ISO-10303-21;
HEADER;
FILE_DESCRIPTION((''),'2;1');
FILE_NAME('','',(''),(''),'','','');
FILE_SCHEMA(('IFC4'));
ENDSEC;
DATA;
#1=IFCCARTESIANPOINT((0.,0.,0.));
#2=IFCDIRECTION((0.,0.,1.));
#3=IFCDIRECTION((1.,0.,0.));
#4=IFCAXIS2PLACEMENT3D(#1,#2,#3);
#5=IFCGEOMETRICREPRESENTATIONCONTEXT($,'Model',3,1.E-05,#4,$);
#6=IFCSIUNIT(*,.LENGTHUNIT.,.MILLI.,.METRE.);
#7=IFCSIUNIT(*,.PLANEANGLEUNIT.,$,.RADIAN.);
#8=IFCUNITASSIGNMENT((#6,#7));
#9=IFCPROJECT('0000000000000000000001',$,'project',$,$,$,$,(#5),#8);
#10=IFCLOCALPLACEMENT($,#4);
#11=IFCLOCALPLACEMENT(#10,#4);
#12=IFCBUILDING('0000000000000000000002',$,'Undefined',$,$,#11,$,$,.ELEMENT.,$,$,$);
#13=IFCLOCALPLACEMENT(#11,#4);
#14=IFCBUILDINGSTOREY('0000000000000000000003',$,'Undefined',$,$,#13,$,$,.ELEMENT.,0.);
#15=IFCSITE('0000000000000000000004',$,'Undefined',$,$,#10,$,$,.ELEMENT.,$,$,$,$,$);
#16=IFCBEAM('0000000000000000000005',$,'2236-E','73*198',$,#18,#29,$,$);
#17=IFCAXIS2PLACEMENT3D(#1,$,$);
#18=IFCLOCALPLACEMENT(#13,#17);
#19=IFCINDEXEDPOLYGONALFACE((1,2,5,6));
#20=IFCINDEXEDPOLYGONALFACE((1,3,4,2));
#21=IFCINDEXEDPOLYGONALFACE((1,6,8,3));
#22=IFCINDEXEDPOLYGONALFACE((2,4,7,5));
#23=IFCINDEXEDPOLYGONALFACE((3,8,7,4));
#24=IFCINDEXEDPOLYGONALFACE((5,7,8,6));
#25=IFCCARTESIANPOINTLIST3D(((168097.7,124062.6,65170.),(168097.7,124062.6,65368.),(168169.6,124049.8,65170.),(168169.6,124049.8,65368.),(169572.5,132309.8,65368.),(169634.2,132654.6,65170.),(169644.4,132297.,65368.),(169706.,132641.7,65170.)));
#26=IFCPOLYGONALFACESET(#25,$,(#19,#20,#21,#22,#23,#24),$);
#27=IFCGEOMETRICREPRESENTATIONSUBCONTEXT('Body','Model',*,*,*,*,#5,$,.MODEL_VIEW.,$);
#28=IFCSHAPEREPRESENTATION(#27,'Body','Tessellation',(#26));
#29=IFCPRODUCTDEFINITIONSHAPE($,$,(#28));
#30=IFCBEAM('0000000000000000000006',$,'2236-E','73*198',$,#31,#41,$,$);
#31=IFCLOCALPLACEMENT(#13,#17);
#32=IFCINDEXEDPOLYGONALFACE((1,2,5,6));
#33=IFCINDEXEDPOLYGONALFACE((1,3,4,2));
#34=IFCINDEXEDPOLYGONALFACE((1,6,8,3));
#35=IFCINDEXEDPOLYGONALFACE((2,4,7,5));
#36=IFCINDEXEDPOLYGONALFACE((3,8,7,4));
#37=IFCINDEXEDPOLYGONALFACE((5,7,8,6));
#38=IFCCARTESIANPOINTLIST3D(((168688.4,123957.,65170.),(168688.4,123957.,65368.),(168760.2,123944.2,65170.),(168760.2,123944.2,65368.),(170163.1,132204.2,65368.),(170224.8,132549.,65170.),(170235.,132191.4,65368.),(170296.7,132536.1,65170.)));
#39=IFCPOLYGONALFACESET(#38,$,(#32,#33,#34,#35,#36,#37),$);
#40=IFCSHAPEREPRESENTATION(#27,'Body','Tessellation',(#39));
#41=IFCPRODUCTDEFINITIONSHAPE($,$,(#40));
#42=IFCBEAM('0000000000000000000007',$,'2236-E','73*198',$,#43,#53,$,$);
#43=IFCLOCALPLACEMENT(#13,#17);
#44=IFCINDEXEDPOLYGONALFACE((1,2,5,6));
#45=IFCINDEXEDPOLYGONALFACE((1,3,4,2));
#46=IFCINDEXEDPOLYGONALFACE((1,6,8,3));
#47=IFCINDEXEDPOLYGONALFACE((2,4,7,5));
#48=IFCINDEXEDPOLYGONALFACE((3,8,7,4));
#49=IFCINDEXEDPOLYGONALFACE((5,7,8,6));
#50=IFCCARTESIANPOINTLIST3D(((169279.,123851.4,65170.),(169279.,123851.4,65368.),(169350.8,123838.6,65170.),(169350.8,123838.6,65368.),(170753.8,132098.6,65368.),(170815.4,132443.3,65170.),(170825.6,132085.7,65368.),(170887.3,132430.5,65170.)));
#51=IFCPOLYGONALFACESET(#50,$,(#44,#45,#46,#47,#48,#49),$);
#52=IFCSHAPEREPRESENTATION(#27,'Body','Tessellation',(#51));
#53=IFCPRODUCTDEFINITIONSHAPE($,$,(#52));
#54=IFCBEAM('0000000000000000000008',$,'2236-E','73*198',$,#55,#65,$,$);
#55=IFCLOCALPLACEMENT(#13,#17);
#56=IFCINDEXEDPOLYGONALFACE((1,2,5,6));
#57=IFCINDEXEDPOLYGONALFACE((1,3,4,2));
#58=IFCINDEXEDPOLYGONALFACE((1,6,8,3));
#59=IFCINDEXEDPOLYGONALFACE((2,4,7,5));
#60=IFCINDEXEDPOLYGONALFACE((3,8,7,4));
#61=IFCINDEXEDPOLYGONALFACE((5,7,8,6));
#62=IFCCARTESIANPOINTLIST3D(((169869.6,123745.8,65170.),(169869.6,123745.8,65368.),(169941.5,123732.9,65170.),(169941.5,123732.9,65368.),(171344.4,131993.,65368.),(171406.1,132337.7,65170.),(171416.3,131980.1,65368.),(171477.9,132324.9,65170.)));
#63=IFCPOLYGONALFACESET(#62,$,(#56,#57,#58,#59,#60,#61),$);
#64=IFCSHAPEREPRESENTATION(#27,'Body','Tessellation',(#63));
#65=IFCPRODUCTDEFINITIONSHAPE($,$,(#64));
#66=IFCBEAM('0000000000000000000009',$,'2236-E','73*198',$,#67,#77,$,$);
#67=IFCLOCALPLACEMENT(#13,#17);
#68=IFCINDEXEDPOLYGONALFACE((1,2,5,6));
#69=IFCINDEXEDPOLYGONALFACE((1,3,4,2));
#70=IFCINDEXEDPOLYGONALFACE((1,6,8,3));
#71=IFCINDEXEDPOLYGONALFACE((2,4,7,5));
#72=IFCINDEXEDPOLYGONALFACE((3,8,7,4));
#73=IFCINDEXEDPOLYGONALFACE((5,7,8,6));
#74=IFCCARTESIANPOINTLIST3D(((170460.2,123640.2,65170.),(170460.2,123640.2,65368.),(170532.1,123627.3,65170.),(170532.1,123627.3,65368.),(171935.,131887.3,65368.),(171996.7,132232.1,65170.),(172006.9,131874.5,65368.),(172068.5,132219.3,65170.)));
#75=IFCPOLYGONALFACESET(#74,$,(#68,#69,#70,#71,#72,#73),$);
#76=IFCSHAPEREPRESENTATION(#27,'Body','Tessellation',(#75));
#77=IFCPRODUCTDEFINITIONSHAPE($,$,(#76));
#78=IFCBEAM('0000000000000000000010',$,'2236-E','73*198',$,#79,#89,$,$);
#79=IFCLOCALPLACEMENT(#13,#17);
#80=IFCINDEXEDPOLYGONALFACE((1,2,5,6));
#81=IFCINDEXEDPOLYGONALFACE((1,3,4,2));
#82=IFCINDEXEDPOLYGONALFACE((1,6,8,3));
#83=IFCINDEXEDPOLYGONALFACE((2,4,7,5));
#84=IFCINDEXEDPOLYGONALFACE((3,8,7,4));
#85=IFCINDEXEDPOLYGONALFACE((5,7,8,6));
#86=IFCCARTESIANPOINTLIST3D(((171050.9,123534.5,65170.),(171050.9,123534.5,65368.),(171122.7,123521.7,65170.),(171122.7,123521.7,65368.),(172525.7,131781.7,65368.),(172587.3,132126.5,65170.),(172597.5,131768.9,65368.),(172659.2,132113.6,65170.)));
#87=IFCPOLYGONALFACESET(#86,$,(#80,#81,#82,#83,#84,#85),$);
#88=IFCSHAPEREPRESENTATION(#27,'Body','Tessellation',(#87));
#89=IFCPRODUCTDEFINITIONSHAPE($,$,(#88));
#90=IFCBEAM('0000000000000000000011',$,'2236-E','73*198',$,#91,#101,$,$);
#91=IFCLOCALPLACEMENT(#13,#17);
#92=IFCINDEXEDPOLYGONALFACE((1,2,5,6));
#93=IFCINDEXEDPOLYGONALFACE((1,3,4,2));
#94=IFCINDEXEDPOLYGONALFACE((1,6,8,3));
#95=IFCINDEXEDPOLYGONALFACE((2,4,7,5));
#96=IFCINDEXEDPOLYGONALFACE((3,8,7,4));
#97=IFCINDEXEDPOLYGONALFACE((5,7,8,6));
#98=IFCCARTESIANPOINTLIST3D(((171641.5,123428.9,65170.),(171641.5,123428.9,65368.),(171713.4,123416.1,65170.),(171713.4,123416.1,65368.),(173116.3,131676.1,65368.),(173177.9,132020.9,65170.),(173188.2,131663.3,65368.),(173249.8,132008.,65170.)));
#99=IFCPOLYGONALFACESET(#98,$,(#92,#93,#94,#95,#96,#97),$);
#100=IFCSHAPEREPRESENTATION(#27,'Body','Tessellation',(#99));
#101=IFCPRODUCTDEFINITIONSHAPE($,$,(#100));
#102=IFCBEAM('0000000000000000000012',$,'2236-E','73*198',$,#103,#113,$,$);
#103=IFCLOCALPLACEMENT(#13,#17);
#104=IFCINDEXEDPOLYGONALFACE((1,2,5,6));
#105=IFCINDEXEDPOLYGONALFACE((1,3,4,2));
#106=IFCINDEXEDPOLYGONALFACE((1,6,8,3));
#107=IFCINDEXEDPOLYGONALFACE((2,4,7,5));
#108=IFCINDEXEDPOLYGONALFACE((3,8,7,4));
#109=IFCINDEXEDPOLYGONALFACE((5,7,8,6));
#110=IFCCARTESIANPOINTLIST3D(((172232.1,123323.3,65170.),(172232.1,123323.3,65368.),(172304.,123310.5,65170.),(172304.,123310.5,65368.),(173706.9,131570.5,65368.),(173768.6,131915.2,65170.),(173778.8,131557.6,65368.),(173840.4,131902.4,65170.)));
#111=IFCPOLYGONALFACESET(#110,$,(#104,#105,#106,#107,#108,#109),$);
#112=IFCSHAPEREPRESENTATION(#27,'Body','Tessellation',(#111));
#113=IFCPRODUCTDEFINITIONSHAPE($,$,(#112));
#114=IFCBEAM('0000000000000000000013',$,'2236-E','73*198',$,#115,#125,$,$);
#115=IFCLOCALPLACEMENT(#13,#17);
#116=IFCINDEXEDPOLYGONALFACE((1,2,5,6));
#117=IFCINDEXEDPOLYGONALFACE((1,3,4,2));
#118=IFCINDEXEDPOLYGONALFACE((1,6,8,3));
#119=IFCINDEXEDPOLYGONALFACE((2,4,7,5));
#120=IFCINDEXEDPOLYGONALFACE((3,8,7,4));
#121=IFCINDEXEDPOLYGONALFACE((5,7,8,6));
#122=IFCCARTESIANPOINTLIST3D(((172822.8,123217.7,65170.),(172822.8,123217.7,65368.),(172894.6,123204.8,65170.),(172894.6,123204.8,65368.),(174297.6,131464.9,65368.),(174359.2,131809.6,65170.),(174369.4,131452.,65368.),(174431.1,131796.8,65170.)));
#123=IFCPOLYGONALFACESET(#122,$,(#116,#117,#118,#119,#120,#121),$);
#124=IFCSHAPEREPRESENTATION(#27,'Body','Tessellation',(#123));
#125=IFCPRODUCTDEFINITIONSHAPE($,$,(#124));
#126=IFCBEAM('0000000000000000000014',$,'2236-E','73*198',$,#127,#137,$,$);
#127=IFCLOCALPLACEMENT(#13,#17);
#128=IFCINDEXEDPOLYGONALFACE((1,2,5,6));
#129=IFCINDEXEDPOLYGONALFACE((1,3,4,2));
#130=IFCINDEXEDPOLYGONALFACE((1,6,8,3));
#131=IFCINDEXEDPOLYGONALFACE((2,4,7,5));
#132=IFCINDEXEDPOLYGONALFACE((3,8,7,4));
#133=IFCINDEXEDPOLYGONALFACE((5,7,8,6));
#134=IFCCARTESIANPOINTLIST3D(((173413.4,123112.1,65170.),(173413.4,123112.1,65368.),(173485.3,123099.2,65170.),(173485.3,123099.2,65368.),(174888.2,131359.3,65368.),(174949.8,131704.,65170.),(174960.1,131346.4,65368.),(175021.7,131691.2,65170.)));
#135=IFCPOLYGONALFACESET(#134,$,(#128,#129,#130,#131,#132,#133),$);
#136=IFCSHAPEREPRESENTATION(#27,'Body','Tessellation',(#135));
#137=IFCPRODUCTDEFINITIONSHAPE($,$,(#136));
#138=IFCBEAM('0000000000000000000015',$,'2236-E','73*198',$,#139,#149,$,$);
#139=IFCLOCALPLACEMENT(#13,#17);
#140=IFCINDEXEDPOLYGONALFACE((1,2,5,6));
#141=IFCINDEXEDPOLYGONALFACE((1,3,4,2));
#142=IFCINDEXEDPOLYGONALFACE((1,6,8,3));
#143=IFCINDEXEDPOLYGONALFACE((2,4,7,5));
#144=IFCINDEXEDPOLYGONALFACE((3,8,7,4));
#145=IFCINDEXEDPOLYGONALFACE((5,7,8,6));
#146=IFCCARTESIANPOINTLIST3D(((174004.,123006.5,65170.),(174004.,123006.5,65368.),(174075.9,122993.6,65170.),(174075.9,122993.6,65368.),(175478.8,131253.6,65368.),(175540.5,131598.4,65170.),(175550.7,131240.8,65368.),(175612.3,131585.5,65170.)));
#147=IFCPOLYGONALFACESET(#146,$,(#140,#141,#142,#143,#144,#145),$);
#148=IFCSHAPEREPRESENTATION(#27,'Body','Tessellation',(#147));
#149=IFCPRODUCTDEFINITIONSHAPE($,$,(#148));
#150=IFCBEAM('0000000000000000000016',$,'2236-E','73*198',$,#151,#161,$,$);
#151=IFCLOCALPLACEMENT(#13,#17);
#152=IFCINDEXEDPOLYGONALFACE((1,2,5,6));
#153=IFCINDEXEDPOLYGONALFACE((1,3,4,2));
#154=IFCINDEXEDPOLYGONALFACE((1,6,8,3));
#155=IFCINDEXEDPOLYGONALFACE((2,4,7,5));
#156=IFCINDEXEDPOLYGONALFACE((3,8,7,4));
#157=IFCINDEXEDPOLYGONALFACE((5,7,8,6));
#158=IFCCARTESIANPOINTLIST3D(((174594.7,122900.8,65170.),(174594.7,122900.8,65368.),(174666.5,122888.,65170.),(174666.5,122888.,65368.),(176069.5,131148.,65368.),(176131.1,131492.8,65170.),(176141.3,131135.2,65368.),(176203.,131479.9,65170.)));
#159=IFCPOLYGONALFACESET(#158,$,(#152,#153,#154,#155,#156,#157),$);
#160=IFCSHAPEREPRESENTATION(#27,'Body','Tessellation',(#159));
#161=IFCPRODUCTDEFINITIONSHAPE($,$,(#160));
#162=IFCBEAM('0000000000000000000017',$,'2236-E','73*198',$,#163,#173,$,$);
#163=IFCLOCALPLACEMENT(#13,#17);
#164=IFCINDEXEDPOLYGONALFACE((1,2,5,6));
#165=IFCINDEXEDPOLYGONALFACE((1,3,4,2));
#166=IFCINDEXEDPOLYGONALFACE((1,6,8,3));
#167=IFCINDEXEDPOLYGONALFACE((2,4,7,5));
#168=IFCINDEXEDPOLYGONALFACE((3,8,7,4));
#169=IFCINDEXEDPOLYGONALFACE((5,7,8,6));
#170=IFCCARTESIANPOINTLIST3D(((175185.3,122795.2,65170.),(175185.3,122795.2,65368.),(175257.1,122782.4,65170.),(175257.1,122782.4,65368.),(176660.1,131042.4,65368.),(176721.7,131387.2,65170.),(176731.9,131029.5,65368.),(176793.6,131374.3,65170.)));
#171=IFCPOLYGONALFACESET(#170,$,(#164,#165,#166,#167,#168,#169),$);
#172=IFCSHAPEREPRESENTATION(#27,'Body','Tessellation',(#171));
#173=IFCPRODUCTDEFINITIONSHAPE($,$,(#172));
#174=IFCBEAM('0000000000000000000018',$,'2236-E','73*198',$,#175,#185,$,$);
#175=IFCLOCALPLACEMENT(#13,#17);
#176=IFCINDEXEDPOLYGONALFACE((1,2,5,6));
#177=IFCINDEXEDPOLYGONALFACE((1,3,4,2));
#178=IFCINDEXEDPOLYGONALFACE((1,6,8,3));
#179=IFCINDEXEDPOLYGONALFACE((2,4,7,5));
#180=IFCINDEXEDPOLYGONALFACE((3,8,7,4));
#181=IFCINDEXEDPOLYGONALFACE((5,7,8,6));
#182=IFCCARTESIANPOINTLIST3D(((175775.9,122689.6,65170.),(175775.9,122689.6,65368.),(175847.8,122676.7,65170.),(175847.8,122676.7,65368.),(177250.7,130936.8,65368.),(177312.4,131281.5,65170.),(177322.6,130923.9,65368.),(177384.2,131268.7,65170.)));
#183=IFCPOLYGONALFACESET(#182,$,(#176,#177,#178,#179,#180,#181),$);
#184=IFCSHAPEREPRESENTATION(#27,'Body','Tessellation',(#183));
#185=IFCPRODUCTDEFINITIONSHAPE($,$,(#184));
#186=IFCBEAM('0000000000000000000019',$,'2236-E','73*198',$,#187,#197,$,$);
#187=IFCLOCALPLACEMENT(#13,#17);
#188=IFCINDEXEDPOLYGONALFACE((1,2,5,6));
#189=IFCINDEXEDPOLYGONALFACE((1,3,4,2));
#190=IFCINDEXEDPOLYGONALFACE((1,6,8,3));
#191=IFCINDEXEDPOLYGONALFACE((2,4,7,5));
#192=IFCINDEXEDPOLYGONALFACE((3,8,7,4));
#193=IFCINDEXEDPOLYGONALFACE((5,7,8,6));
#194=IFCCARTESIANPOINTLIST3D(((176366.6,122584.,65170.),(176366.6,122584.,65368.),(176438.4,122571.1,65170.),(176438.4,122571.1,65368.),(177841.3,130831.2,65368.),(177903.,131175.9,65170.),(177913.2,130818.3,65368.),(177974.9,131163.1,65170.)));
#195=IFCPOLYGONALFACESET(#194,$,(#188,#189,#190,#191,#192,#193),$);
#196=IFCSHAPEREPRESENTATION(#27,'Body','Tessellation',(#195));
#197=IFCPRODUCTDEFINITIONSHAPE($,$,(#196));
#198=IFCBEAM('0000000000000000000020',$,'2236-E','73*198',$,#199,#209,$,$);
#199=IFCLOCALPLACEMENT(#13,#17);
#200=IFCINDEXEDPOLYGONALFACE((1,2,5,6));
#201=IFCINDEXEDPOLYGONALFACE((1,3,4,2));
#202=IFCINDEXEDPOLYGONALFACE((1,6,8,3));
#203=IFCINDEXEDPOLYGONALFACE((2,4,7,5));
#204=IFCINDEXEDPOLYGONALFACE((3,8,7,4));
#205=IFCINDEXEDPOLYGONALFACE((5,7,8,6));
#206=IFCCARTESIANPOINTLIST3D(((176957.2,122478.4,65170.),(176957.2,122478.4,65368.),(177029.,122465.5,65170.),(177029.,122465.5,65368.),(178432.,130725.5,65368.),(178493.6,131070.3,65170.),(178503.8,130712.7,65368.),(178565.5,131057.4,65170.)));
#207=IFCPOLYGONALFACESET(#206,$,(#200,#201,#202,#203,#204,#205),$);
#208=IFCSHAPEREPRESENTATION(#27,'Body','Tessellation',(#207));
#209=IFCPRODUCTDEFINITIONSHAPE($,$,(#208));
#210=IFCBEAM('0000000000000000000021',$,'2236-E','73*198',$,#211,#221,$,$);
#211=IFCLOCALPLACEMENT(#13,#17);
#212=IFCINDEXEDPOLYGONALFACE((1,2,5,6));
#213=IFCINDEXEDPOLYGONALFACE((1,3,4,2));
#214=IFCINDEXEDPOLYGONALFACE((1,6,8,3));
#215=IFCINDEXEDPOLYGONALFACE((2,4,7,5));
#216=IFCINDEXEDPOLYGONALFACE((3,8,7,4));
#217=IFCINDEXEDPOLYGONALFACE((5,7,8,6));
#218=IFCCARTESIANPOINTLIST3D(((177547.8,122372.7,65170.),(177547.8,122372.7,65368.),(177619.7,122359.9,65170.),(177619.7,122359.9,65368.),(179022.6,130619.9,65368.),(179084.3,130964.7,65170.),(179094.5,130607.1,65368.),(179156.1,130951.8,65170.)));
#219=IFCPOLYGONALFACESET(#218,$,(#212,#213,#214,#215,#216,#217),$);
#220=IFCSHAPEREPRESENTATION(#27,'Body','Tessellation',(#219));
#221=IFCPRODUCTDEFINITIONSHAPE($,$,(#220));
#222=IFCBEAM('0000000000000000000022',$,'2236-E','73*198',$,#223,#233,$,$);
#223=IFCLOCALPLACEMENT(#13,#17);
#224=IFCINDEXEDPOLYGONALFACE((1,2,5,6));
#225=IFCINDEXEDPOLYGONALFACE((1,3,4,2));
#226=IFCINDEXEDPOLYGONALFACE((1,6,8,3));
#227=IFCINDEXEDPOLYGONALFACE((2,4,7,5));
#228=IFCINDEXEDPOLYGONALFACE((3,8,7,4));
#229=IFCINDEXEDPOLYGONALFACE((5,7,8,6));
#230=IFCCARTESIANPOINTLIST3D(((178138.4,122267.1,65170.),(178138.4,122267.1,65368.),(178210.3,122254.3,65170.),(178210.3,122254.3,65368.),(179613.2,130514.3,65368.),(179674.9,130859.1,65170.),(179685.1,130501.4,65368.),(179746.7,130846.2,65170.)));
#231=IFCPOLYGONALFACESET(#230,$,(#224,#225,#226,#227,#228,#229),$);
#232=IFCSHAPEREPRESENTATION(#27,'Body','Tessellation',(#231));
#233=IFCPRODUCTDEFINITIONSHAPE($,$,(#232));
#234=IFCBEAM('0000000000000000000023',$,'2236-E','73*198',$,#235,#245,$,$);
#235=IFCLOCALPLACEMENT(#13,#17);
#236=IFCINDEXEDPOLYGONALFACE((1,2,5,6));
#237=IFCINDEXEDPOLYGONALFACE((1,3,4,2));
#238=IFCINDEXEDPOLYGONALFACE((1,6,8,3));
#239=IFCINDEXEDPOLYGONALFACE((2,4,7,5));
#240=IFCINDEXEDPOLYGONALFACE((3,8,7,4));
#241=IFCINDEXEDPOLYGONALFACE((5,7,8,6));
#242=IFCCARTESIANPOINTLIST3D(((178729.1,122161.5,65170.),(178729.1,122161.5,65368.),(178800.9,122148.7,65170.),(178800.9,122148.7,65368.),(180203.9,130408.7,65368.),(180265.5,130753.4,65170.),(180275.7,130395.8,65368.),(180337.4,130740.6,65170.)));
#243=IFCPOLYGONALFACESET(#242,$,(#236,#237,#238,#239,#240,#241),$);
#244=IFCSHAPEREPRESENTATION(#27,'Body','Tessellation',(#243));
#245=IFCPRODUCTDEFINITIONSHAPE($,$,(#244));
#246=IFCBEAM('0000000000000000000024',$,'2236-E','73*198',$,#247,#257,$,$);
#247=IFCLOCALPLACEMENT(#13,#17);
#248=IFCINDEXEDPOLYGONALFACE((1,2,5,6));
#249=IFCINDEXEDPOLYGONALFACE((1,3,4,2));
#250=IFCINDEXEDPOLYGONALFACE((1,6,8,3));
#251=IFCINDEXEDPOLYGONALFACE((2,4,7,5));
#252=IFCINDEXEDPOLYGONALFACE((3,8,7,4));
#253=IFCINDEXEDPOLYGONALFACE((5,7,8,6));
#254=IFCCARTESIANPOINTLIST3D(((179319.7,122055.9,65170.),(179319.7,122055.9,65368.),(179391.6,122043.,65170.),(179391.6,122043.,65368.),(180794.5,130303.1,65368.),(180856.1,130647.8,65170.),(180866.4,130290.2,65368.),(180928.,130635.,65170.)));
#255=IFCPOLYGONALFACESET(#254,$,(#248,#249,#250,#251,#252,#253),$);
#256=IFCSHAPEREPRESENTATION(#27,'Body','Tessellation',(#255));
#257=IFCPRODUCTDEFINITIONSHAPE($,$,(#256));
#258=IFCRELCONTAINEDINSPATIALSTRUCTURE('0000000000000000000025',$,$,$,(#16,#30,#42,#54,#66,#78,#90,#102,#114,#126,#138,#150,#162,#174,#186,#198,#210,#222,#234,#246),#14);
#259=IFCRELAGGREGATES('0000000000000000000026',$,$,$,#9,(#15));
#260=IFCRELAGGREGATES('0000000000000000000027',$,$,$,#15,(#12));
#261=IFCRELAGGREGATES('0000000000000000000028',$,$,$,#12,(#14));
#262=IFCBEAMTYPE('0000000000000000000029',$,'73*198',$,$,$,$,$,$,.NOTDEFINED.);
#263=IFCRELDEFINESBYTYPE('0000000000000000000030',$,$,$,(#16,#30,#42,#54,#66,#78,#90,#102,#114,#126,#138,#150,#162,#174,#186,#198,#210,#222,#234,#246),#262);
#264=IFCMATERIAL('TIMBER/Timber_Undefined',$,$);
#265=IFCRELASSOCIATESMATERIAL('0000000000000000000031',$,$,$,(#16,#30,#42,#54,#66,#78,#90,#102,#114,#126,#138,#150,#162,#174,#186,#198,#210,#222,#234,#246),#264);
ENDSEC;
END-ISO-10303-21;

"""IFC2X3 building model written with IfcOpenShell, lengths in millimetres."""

from ifc_helpers import new_model, si_unit, frame, origin_with_axes, origin_2d_with_axis, place, context, subcontext, project, spatial, rectangle, extrude, clip, halfspace, material, type_object, element, save


model = new_model("IFC2X3")

# Units and contexts
model_context = context("Model", 3, precision=1e-05, world=origin_with_axes())
body_context = subcontext(model_context, "Body", "Model", "MODEL_VIEW")
ifc_project = project(units=[si_unit("LENGTHUNIT", "METRE", prefix="MILLI"), si_unit("PLANEANGLEUNIT", "RADIAN")], contexts=[model_context])

# Site, building, storey
site_placement = place(None, origin_with_axes())
site = spatial("IfcSite", under=ifc_project, at=site_placement, Name="Undefined", CompositionType="ELEMENT")
building_placement = place(site_placement, origin_with_axes())
building = spatial("IfcBuilding", under=site, at=building_placement, Name="Undefined", CompositionType="ELEMENT")
storey_placement = place(building_placement, origin_with_axes())
storey = spatial("IfcBuildingStorey", under=building, at=storey_placement, Name="Undefined", CompositionType="ELEMENT", Elevation=0.0)

# Beams
ifc_material_1 = material(Name="TIMBER/Timber_Undefined")
beam_type_1 = type_object("IfcBeamType", Name="73*198", PredefinedType="NOTDEFINED")
for number, where, z_axis, x_axis, name in (
    (1, (168133.7, 124056.2, 65269.0), (-0.984385, 0.176032, 0.0), (0.176032, 0.984385, 0.0), "2236-E"),
    (2, (168724.3, 123950.6, 65269.0), (-0.984385, 0.176032, 0.0), (0.176032, 0.984385, 0.0), "2236-E"),
    (3, (169314.9, 123845.0, 65269.0), (-0.984385, 0.176032, 0.0), (0.176032, 0.984385, 0.0), "2236-E"),
    (4, (169905.5, 123739.4, 65269.0), (-0.984385, 0.176032, 0.0), (0.176032, 0.984385, 0.0), "2236-E"),
    (5, (170496.2, 123633.7, 65269.0), (-0.984385, 0.176032, 0.0), (0.176032, 0.984385, 0.0), "2236-E"),
    (6, (171086.8, 123528.1, 65269.0), (-0.984385, 0.176032, 0.0), (0.176032, 0.984385, 0.0), "2236-E"),
    (7, (171677.4, 123422.5, 65269.0), (-0.984385, 0.176032, 0.0), (0.176032, 0.984385, 0.0), "2236-E"),
    (8, (172268.1, 123316.9, 65269.0), (-0.984385, 0.176032, 0.0), (0.176032, 0.984385, 0.0), "2236-E"),
    (9, (172858.7, 123211.3, 65269.0), (-0.984385, 0.176032, 0.0), (0.176032, 0.984385, 0.0), "2236-E"),
    (10, (173449.3, 123105.6, 65269.0), (-0.984385, 0.176032, 0.0), (0.176032, 0.984385, 0.0), "2236-E"),
    (11, (174040.0, 123000.0, 65269.0), (-0.984385, 0.176032, 0.0), (0.176032, 0.984385, 0.0), "2236-E"),
    (12, (174630.6, 122894.4, 65269.0), (-0.984385, 0.176032, 0.0), (0.176032, 0.984385, 0.0), "2236-E"),
    (13, (175221.2, 122788.8, 65269.0), (-0.984385, 0.176032, 0.0), (0.176032, 0.984385, 0.0), "2236-E"),
    (14, (175811.9, 122683.2, 65269.0), (-0.984385, 0.176032, 0.0), (0.176032, 0.984385, 0.0), "2236-E"),
    (15, (176402.5, 122577.6, 65269.0), (-0.984385, 0.176032, 0.0), (0.176032, 0.984385, 0.0), "2236-E"),
    (16, (176993.1, 122471.9, 65269.0), (-0.984385, 0.176032, 0.0), (0.176032, 0.984385, 0.0), "2236-E"),
    (17, (177583.7, 122366.3, 65269.0), (-0.984385, 0.176032, 0.0), (0.176032, 0.984385, 0.0), "2236-E"),
    (18, (178174.4, 122260.7, 65269.0), (-0.984385, 0.176032, 0.0), (0.176032, 0.984385, 0.0), "2236-E"),
    (19, (178765.0, 122155.1, 65269.0), (-0.984385, 0.176032, 0.0), (0.176032, 0.984385, 0.0), "2236-E"),
    (20, (179355.6, 122049.5, 65269.0), (-0.984385, 0.176032, 0.0), (0.176032, 0.984385, 0.0), "2236-E"),
):
    element("IfcBeam", number, at=place(storey_placement, frame(where, z_axis=z_axis, x_axis=x_axis)), inside=storey, type_object=beam_type_1, material=ifc_material_1, Name=name, Description="73*198", context=body_context, shape_type="Clipping", body=[
        clip(extrude(rectangle(XDim=198.0, YDim=73.0, at=origin_2d_with_axis()), frame((14325.0, 0.0, 0.0), z_axis=(-1.0, 0.0, 0.0), x_axis=(0.0, -1.0, 0.0)), (0.0, 0.0, 1.0), 14325.0), halfspace(frame((8728.2, 99.0, 36.5), z_axis=(0.492144, -0.870514, 0.0), x_axis=(0.0, 0.0, -1.0)), False)),
    ])

save(model, "model.ifc")
